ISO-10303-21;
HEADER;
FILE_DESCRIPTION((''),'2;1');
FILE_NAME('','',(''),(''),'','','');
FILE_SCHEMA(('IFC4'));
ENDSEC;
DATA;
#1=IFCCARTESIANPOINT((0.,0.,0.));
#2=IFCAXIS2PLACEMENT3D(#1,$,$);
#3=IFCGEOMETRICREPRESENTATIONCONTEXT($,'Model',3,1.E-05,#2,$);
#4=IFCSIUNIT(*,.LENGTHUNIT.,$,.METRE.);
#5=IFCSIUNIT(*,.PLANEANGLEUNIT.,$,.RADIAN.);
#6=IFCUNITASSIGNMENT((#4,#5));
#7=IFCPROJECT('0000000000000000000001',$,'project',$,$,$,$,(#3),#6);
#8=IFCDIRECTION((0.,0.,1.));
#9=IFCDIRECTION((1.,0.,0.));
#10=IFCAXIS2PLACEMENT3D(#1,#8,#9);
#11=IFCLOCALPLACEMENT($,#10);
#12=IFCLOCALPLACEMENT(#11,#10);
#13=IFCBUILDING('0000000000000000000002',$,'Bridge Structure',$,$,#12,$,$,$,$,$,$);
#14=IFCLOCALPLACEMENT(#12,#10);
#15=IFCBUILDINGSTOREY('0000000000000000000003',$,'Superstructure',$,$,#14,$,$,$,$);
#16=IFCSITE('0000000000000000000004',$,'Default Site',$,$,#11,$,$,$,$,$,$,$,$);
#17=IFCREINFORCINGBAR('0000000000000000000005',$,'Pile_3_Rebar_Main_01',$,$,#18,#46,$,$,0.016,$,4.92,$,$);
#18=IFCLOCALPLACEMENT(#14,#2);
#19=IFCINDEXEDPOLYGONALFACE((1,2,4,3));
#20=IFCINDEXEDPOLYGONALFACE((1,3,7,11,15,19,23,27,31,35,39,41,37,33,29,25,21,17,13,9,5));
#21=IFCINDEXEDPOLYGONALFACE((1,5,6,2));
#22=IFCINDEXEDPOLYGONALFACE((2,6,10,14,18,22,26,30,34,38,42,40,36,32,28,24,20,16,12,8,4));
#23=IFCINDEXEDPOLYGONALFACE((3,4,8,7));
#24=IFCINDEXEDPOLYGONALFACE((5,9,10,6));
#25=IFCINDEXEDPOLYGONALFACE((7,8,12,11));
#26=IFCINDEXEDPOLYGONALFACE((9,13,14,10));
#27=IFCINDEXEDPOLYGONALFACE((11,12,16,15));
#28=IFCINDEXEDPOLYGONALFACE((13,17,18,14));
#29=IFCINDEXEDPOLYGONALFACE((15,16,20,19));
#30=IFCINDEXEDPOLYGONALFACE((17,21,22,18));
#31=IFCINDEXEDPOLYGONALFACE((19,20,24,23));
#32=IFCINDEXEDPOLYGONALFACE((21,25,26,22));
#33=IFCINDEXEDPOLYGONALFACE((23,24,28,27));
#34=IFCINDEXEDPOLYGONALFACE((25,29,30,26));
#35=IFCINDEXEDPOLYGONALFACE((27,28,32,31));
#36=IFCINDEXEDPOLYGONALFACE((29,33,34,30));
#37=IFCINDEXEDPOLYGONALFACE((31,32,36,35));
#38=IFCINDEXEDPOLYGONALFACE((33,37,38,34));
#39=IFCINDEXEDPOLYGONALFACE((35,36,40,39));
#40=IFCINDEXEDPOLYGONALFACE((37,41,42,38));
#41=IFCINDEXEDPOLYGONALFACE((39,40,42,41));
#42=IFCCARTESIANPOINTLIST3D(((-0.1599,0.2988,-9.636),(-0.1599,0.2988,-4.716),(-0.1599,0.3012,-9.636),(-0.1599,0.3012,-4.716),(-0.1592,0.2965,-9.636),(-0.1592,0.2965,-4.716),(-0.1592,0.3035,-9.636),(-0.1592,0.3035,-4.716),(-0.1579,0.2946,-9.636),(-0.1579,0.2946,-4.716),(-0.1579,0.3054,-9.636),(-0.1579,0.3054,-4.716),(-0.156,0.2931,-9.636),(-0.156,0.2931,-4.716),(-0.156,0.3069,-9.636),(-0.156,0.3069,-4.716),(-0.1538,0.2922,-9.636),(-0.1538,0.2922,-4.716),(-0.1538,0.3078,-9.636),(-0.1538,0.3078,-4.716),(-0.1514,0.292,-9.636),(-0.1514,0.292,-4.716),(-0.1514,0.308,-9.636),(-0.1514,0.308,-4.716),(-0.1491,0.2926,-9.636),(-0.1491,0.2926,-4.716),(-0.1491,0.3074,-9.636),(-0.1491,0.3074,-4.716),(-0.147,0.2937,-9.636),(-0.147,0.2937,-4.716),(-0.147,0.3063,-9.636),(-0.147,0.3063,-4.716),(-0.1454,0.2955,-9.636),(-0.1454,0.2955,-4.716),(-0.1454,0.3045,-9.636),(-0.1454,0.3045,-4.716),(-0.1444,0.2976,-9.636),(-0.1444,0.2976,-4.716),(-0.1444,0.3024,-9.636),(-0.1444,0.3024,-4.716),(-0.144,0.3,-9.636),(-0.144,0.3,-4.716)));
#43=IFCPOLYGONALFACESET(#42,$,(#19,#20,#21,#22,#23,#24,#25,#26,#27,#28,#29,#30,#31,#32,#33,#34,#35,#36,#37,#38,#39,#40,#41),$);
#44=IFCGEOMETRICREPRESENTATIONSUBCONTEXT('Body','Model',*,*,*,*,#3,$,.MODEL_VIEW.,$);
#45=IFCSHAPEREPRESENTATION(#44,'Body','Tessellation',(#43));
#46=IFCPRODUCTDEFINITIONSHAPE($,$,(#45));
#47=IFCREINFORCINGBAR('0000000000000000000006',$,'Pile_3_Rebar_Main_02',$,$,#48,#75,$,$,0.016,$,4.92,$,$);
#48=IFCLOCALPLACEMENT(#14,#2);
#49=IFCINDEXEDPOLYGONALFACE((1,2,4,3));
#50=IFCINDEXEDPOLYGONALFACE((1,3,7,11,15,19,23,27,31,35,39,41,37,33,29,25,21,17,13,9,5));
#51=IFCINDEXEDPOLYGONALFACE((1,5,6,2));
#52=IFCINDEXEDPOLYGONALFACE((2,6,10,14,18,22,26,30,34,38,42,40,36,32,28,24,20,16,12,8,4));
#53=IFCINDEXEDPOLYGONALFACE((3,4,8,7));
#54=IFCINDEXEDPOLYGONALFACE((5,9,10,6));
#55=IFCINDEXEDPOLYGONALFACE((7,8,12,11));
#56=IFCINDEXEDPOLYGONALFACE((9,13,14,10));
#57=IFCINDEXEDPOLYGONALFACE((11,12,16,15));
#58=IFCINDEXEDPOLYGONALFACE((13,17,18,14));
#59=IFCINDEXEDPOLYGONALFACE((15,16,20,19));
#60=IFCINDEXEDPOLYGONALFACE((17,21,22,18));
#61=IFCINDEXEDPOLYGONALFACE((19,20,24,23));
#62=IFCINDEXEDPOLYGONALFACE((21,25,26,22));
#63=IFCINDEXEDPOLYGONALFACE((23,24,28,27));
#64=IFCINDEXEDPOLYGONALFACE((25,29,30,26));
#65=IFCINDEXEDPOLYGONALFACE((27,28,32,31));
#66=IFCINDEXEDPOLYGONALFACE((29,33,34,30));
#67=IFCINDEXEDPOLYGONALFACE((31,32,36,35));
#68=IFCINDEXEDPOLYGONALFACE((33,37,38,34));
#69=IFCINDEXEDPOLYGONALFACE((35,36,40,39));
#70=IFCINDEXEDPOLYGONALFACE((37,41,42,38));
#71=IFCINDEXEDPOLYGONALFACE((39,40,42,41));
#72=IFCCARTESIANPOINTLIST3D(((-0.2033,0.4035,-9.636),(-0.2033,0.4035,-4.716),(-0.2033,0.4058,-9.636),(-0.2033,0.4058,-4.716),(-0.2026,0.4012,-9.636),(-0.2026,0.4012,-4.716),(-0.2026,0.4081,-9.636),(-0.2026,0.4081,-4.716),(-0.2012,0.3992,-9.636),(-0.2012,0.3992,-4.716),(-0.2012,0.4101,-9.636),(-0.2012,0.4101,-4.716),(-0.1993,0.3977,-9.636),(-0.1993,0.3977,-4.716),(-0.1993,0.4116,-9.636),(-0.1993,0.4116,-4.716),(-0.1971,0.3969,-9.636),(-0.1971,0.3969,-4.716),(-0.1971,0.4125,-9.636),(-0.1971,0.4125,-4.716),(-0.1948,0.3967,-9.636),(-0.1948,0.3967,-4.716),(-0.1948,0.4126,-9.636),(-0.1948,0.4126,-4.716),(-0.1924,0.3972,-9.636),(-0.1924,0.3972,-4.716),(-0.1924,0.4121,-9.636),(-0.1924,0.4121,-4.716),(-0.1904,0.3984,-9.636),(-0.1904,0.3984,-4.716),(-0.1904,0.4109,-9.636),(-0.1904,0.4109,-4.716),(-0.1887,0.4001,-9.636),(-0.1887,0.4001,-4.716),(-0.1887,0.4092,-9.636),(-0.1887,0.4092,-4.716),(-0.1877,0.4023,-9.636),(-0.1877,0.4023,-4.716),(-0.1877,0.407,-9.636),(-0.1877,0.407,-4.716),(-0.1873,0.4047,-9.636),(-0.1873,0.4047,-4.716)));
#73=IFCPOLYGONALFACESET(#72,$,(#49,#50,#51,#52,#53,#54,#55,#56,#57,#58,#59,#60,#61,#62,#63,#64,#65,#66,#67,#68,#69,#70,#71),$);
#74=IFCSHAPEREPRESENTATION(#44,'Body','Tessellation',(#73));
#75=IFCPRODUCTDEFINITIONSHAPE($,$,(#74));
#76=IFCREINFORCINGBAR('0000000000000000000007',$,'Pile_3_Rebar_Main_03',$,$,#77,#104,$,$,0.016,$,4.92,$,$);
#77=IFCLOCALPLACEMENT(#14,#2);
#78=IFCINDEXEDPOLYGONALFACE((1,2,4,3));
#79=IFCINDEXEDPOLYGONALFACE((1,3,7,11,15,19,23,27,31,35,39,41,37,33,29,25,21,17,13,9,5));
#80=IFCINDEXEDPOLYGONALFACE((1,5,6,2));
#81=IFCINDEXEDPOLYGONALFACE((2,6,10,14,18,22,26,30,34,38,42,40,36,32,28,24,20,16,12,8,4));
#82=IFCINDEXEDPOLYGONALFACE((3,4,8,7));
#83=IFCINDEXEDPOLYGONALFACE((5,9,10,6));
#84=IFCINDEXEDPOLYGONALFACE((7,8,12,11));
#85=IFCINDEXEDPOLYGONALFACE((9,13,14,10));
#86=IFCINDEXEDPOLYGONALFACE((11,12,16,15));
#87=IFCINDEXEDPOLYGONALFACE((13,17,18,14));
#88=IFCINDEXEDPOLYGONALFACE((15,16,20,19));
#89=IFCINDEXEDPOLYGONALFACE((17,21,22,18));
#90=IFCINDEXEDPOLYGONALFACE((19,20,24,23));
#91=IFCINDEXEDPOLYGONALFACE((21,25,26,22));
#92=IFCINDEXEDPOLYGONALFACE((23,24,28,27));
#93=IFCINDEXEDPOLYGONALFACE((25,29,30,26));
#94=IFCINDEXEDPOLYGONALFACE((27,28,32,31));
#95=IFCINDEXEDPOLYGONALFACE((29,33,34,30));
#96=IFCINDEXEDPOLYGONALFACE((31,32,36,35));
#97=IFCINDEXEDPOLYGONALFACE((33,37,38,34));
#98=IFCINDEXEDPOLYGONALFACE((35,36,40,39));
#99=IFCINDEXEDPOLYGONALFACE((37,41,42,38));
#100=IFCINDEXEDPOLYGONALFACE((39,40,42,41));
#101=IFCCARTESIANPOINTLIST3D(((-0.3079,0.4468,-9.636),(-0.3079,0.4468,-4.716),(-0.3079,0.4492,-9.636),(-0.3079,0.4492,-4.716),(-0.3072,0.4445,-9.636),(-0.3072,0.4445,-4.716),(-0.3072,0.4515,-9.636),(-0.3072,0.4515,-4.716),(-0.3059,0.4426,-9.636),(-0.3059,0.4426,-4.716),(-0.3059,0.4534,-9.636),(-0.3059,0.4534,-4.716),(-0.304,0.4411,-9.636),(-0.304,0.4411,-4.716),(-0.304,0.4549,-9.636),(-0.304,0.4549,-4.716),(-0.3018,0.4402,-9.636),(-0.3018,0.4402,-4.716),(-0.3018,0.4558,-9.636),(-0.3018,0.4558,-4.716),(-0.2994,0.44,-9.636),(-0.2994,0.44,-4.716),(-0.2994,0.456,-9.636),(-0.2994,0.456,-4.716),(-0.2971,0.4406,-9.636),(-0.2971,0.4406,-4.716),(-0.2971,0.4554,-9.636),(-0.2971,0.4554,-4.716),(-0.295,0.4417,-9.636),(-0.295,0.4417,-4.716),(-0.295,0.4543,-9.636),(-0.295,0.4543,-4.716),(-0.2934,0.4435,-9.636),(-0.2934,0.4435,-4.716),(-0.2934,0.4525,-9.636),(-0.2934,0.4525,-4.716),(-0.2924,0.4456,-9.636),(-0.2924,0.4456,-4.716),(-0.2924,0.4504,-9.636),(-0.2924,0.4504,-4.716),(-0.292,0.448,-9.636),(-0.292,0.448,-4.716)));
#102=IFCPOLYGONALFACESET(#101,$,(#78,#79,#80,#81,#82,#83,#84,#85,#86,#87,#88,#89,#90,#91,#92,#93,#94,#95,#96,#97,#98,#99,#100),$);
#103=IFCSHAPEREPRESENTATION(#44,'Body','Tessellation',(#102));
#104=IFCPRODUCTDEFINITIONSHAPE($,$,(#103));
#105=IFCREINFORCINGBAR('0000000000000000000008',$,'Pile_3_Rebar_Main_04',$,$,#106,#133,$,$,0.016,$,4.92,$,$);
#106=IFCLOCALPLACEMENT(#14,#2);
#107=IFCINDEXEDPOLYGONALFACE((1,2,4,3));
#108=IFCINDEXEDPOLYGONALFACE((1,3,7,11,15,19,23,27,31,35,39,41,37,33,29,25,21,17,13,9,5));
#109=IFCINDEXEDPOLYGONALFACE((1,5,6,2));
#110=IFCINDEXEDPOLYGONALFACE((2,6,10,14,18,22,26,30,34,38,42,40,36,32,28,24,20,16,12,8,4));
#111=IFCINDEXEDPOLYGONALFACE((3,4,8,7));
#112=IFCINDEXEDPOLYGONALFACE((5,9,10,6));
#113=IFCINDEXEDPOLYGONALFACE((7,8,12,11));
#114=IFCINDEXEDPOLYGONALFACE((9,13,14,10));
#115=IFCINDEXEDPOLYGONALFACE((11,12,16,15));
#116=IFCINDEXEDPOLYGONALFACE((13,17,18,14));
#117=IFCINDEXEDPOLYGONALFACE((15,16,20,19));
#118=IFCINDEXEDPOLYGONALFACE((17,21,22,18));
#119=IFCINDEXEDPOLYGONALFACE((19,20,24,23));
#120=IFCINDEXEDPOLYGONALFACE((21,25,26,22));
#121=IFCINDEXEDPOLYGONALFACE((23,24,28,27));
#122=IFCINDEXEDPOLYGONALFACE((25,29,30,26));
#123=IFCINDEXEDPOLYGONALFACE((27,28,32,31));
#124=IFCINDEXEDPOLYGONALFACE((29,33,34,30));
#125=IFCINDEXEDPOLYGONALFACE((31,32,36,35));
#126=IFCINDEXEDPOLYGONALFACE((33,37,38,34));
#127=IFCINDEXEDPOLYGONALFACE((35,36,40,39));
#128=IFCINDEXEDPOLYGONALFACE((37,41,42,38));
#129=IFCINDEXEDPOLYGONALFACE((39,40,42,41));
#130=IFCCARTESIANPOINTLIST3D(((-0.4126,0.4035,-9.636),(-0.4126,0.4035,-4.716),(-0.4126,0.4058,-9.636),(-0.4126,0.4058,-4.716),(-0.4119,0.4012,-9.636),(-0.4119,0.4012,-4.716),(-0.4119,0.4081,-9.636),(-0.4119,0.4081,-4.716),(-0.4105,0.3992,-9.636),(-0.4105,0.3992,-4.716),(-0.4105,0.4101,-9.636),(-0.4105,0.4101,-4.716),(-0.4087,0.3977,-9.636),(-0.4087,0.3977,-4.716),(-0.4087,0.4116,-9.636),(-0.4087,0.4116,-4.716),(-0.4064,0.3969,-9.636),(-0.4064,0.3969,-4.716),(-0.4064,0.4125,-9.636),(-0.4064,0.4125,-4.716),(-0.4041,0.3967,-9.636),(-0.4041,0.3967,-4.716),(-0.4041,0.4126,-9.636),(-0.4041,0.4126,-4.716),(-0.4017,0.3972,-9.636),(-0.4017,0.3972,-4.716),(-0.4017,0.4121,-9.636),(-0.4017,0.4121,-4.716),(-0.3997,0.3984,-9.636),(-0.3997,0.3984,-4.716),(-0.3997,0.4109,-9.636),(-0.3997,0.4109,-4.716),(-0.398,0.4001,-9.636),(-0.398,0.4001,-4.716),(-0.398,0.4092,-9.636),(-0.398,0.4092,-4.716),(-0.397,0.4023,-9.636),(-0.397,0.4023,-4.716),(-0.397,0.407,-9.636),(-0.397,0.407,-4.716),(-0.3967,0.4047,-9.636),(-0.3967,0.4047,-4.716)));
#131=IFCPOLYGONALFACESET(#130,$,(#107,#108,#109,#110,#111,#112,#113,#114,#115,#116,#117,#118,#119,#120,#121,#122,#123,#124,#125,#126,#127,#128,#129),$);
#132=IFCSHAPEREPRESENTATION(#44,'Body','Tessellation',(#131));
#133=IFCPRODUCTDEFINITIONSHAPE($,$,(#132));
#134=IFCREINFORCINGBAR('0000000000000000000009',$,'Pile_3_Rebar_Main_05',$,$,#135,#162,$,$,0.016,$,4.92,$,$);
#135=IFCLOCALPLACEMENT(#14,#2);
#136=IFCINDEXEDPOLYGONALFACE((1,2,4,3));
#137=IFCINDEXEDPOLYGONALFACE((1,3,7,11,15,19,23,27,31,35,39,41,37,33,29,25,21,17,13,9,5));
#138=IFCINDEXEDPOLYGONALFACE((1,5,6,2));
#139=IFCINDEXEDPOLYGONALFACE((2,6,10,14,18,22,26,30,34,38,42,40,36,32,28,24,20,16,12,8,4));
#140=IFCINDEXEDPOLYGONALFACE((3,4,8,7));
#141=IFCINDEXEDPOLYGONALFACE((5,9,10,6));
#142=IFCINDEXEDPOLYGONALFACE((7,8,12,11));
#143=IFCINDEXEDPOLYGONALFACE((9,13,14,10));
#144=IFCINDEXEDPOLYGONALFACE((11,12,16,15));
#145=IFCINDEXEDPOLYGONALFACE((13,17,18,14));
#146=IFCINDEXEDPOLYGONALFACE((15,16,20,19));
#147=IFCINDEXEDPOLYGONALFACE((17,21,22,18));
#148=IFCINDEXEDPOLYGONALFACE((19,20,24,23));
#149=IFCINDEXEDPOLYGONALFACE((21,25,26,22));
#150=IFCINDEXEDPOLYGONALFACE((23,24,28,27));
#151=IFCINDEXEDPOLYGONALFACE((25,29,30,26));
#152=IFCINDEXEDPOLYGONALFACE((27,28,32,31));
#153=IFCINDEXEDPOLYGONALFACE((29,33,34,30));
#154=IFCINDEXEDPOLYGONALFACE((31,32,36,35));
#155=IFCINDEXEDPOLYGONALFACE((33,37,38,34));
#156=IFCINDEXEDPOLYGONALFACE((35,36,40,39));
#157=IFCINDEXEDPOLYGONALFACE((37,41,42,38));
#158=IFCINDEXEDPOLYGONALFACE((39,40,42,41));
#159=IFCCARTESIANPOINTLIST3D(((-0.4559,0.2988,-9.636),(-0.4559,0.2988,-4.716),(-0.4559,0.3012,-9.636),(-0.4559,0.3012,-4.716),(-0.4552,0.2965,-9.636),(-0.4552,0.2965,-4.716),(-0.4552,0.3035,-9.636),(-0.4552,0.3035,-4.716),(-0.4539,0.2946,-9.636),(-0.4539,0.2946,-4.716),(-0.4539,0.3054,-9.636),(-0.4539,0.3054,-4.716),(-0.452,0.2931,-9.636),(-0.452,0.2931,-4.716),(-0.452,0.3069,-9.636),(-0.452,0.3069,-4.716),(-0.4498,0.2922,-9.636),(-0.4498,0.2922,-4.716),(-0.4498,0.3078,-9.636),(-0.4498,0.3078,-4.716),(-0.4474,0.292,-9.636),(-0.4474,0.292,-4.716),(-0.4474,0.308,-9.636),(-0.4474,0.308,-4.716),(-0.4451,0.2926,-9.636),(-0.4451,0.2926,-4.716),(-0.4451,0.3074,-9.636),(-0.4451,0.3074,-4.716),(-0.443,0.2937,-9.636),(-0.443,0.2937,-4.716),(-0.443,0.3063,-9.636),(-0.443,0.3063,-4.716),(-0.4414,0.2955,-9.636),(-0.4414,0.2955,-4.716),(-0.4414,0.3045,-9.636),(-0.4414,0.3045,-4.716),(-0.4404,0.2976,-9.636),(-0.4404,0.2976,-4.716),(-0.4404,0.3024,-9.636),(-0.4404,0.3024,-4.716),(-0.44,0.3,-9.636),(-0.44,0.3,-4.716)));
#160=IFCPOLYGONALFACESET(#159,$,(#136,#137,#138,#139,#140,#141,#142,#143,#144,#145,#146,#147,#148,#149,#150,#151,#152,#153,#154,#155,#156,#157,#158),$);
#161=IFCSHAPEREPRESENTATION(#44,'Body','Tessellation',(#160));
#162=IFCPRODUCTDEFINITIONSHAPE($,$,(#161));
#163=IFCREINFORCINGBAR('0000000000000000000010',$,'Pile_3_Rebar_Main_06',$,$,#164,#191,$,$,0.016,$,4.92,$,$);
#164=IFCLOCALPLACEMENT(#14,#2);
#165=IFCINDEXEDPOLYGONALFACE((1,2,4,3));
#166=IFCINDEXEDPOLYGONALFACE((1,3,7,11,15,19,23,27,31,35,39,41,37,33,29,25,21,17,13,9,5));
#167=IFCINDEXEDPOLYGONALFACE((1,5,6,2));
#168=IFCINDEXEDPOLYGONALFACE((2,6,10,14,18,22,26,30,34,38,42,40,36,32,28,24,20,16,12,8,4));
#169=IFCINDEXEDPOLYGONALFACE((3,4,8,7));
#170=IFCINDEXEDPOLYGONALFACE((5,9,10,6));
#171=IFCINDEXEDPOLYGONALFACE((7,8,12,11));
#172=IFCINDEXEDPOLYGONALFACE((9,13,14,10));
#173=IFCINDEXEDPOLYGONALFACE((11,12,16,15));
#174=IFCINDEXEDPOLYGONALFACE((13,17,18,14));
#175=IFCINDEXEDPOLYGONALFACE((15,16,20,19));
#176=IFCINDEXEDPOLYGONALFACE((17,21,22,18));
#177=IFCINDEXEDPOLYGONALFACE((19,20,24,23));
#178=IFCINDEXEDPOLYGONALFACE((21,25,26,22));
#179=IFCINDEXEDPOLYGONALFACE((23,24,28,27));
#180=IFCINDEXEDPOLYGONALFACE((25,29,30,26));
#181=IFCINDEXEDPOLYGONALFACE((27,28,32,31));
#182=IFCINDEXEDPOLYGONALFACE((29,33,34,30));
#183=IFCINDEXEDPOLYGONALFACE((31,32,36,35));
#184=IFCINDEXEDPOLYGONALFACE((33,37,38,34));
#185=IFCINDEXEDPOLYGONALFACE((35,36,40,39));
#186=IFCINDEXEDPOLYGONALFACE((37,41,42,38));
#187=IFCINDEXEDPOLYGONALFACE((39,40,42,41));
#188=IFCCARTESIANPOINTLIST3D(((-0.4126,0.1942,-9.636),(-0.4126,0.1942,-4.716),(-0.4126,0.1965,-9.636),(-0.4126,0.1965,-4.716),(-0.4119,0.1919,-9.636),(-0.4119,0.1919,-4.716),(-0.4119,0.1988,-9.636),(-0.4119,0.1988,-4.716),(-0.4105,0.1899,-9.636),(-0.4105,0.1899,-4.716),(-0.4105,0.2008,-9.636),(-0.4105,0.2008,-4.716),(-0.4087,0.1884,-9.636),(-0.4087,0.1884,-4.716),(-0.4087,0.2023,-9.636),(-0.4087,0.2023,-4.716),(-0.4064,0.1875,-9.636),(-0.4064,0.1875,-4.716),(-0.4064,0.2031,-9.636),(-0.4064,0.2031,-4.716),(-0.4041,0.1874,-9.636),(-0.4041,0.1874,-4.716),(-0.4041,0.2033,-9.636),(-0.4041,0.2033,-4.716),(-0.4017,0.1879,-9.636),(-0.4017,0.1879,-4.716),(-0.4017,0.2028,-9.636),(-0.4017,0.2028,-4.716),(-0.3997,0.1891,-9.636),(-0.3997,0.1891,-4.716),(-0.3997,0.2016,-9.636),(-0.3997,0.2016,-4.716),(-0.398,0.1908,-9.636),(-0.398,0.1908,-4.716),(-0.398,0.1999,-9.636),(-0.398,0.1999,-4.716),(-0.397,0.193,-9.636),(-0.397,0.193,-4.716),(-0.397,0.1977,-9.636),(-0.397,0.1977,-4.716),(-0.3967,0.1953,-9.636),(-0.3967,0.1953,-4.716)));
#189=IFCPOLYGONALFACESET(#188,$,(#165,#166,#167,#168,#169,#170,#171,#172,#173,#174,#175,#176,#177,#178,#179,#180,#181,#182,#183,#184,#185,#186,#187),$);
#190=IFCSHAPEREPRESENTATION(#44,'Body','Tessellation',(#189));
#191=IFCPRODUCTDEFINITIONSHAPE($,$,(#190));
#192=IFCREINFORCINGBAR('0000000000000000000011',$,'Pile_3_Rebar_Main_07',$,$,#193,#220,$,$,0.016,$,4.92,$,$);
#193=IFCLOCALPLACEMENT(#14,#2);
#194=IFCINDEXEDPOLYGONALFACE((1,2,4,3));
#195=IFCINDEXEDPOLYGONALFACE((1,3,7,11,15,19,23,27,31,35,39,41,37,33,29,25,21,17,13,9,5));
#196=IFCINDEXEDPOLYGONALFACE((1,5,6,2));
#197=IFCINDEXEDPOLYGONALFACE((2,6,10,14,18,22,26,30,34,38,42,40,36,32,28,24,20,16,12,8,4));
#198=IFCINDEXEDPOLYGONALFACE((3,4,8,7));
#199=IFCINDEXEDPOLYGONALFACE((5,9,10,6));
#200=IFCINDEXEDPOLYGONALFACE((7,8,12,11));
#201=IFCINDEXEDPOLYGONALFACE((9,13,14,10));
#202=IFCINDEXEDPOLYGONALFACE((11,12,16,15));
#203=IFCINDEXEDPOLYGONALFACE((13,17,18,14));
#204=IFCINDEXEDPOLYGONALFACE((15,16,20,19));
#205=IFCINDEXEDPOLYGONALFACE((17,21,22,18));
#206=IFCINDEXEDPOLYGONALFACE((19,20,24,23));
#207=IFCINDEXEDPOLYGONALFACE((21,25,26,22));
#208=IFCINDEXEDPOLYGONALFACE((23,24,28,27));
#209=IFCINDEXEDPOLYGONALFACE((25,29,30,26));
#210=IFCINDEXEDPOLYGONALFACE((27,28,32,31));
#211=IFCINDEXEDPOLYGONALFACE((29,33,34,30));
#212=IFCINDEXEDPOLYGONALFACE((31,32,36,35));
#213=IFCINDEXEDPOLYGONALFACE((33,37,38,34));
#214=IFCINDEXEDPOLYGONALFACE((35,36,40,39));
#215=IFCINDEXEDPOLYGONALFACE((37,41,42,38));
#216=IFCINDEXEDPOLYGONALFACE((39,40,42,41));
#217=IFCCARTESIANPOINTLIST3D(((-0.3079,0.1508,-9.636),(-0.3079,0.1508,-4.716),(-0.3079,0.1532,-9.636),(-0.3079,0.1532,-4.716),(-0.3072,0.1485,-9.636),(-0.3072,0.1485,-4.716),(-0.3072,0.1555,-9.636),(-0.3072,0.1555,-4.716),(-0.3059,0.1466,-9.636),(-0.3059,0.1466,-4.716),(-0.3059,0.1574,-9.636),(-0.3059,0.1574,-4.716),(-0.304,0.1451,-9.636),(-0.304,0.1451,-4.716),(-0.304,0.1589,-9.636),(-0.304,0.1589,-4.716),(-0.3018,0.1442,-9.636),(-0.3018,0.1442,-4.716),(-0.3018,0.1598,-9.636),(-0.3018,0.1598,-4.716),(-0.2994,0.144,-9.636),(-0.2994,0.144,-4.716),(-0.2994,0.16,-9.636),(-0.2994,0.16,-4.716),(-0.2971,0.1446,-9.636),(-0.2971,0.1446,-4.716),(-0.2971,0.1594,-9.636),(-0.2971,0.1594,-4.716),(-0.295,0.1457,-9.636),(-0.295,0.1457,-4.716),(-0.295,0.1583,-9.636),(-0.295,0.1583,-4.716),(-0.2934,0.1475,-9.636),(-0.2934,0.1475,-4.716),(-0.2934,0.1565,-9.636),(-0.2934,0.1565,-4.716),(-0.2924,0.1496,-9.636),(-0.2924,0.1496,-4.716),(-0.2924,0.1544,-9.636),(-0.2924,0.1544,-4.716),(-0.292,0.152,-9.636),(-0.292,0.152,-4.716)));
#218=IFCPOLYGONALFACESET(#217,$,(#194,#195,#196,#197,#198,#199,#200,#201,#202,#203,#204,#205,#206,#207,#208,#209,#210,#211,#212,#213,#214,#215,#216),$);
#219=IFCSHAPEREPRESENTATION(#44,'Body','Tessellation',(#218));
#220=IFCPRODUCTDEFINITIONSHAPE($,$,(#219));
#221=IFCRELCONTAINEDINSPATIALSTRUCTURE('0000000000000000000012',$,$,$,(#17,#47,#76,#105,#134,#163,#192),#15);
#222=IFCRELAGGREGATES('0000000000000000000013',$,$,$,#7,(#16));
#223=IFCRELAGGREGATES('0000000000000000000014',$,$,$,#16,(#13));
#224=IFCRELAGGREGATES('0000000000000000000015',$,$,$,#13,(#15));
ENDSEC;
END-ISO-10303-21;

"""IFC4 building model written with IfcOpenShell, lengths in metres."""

from ifc_helpers import new_model, si_unit, frame, origin, origin_with_axes, origin_2d_with_axis, place, context, subcontext, project, spatial, circle, extrude, element, save


model = new_model("IFC4")

# Units and contexts
model_context = context("Model", 3, precision=1e-05, world=origin())
body_context = subcontext(model_context, "Body", "Model", "MODEL_VIEW")
ifc_project = project(units=[si_unit("LENGTHUNIT", "METRE"), si_unit("PLANEANGLEUNIT", "RADIAN")], contexts=[model_context])

# Site, building, storey
site_placement = place(None, origin_with_axes())
site = spatial("IfcSite", under=ifc_project, at=site_placement, Name="Default Site")
building_placement = place(site_placement, origin_with_axes())
building = spatial("IfcBuilding", under=site, at=building_placement, Name="Bridge Structure")
storey_placement = place(building_placement, origin_with_axes())
storey = spatial("IfcBuildingStorey", under=building, at=storey_placement, Name="Superstructure")

# Reinforcing bars
for number, where, z_axis, x_axis, name in (
    (1, (-0.152, 0.3, -9.636), (0.0, 0.0, 1.0), (1.0, 0.0, 0.0), "Pile_3_Rebar_Main_01"),
    (2, (-0.1953, 0.4047, -9.636), (0.0, 0.0, 1.0), (1.0, 0.0, 0.0), "Pile_3_Rebar_Main_02"),
    (3, (-0.3, 0.448, -9.636), (0.0, 0.0, 1.0), (1.0, 0.0, 0.0), "Pile_3_Rebar_Main_03"),
    (4, (-0.4047, 0.4047, -9.636), (0.0, 0.0, 1.0), (1.0, 0.0, 0.0), "Pile_3_Rebar_Main_04"),
    (5, (-0.448, 0.3, -9.636), (0.0, 0.0, 1.0), (1.0, 0.0, 0.0), "Pile_3_Rebar_Main_05"),
    (6, (-0.4047, 0.1953, -9.636), (0.0, 0.0, 1.0), (1.0, 0.0, 0.0), "Pile_3_Rebar_Main_06"),
    (7, (-0.3, 0.152, -9.636), (0.0, 0.0, 1.0), (1.0, 0.0, 0.0), "Pile_3_Rebar_Main_07"),
):
    element("IfcReinforcingBar", number, at=place(storey_placement, frame(where, z_axis=z_axis, x_axis=x_axis)), inside=storey, Name=name, BarLength=4.92, NominalDiameter=0.016, context=body_context, shape_type="SweptSolid", body=[
        extrude(circle(Radius=0.008, at=origin_2d_with_axis()), origin_with_axes(), (0.0, 0.0, 1.0), 4.92),
    ])

save(model, "model.ifc")
